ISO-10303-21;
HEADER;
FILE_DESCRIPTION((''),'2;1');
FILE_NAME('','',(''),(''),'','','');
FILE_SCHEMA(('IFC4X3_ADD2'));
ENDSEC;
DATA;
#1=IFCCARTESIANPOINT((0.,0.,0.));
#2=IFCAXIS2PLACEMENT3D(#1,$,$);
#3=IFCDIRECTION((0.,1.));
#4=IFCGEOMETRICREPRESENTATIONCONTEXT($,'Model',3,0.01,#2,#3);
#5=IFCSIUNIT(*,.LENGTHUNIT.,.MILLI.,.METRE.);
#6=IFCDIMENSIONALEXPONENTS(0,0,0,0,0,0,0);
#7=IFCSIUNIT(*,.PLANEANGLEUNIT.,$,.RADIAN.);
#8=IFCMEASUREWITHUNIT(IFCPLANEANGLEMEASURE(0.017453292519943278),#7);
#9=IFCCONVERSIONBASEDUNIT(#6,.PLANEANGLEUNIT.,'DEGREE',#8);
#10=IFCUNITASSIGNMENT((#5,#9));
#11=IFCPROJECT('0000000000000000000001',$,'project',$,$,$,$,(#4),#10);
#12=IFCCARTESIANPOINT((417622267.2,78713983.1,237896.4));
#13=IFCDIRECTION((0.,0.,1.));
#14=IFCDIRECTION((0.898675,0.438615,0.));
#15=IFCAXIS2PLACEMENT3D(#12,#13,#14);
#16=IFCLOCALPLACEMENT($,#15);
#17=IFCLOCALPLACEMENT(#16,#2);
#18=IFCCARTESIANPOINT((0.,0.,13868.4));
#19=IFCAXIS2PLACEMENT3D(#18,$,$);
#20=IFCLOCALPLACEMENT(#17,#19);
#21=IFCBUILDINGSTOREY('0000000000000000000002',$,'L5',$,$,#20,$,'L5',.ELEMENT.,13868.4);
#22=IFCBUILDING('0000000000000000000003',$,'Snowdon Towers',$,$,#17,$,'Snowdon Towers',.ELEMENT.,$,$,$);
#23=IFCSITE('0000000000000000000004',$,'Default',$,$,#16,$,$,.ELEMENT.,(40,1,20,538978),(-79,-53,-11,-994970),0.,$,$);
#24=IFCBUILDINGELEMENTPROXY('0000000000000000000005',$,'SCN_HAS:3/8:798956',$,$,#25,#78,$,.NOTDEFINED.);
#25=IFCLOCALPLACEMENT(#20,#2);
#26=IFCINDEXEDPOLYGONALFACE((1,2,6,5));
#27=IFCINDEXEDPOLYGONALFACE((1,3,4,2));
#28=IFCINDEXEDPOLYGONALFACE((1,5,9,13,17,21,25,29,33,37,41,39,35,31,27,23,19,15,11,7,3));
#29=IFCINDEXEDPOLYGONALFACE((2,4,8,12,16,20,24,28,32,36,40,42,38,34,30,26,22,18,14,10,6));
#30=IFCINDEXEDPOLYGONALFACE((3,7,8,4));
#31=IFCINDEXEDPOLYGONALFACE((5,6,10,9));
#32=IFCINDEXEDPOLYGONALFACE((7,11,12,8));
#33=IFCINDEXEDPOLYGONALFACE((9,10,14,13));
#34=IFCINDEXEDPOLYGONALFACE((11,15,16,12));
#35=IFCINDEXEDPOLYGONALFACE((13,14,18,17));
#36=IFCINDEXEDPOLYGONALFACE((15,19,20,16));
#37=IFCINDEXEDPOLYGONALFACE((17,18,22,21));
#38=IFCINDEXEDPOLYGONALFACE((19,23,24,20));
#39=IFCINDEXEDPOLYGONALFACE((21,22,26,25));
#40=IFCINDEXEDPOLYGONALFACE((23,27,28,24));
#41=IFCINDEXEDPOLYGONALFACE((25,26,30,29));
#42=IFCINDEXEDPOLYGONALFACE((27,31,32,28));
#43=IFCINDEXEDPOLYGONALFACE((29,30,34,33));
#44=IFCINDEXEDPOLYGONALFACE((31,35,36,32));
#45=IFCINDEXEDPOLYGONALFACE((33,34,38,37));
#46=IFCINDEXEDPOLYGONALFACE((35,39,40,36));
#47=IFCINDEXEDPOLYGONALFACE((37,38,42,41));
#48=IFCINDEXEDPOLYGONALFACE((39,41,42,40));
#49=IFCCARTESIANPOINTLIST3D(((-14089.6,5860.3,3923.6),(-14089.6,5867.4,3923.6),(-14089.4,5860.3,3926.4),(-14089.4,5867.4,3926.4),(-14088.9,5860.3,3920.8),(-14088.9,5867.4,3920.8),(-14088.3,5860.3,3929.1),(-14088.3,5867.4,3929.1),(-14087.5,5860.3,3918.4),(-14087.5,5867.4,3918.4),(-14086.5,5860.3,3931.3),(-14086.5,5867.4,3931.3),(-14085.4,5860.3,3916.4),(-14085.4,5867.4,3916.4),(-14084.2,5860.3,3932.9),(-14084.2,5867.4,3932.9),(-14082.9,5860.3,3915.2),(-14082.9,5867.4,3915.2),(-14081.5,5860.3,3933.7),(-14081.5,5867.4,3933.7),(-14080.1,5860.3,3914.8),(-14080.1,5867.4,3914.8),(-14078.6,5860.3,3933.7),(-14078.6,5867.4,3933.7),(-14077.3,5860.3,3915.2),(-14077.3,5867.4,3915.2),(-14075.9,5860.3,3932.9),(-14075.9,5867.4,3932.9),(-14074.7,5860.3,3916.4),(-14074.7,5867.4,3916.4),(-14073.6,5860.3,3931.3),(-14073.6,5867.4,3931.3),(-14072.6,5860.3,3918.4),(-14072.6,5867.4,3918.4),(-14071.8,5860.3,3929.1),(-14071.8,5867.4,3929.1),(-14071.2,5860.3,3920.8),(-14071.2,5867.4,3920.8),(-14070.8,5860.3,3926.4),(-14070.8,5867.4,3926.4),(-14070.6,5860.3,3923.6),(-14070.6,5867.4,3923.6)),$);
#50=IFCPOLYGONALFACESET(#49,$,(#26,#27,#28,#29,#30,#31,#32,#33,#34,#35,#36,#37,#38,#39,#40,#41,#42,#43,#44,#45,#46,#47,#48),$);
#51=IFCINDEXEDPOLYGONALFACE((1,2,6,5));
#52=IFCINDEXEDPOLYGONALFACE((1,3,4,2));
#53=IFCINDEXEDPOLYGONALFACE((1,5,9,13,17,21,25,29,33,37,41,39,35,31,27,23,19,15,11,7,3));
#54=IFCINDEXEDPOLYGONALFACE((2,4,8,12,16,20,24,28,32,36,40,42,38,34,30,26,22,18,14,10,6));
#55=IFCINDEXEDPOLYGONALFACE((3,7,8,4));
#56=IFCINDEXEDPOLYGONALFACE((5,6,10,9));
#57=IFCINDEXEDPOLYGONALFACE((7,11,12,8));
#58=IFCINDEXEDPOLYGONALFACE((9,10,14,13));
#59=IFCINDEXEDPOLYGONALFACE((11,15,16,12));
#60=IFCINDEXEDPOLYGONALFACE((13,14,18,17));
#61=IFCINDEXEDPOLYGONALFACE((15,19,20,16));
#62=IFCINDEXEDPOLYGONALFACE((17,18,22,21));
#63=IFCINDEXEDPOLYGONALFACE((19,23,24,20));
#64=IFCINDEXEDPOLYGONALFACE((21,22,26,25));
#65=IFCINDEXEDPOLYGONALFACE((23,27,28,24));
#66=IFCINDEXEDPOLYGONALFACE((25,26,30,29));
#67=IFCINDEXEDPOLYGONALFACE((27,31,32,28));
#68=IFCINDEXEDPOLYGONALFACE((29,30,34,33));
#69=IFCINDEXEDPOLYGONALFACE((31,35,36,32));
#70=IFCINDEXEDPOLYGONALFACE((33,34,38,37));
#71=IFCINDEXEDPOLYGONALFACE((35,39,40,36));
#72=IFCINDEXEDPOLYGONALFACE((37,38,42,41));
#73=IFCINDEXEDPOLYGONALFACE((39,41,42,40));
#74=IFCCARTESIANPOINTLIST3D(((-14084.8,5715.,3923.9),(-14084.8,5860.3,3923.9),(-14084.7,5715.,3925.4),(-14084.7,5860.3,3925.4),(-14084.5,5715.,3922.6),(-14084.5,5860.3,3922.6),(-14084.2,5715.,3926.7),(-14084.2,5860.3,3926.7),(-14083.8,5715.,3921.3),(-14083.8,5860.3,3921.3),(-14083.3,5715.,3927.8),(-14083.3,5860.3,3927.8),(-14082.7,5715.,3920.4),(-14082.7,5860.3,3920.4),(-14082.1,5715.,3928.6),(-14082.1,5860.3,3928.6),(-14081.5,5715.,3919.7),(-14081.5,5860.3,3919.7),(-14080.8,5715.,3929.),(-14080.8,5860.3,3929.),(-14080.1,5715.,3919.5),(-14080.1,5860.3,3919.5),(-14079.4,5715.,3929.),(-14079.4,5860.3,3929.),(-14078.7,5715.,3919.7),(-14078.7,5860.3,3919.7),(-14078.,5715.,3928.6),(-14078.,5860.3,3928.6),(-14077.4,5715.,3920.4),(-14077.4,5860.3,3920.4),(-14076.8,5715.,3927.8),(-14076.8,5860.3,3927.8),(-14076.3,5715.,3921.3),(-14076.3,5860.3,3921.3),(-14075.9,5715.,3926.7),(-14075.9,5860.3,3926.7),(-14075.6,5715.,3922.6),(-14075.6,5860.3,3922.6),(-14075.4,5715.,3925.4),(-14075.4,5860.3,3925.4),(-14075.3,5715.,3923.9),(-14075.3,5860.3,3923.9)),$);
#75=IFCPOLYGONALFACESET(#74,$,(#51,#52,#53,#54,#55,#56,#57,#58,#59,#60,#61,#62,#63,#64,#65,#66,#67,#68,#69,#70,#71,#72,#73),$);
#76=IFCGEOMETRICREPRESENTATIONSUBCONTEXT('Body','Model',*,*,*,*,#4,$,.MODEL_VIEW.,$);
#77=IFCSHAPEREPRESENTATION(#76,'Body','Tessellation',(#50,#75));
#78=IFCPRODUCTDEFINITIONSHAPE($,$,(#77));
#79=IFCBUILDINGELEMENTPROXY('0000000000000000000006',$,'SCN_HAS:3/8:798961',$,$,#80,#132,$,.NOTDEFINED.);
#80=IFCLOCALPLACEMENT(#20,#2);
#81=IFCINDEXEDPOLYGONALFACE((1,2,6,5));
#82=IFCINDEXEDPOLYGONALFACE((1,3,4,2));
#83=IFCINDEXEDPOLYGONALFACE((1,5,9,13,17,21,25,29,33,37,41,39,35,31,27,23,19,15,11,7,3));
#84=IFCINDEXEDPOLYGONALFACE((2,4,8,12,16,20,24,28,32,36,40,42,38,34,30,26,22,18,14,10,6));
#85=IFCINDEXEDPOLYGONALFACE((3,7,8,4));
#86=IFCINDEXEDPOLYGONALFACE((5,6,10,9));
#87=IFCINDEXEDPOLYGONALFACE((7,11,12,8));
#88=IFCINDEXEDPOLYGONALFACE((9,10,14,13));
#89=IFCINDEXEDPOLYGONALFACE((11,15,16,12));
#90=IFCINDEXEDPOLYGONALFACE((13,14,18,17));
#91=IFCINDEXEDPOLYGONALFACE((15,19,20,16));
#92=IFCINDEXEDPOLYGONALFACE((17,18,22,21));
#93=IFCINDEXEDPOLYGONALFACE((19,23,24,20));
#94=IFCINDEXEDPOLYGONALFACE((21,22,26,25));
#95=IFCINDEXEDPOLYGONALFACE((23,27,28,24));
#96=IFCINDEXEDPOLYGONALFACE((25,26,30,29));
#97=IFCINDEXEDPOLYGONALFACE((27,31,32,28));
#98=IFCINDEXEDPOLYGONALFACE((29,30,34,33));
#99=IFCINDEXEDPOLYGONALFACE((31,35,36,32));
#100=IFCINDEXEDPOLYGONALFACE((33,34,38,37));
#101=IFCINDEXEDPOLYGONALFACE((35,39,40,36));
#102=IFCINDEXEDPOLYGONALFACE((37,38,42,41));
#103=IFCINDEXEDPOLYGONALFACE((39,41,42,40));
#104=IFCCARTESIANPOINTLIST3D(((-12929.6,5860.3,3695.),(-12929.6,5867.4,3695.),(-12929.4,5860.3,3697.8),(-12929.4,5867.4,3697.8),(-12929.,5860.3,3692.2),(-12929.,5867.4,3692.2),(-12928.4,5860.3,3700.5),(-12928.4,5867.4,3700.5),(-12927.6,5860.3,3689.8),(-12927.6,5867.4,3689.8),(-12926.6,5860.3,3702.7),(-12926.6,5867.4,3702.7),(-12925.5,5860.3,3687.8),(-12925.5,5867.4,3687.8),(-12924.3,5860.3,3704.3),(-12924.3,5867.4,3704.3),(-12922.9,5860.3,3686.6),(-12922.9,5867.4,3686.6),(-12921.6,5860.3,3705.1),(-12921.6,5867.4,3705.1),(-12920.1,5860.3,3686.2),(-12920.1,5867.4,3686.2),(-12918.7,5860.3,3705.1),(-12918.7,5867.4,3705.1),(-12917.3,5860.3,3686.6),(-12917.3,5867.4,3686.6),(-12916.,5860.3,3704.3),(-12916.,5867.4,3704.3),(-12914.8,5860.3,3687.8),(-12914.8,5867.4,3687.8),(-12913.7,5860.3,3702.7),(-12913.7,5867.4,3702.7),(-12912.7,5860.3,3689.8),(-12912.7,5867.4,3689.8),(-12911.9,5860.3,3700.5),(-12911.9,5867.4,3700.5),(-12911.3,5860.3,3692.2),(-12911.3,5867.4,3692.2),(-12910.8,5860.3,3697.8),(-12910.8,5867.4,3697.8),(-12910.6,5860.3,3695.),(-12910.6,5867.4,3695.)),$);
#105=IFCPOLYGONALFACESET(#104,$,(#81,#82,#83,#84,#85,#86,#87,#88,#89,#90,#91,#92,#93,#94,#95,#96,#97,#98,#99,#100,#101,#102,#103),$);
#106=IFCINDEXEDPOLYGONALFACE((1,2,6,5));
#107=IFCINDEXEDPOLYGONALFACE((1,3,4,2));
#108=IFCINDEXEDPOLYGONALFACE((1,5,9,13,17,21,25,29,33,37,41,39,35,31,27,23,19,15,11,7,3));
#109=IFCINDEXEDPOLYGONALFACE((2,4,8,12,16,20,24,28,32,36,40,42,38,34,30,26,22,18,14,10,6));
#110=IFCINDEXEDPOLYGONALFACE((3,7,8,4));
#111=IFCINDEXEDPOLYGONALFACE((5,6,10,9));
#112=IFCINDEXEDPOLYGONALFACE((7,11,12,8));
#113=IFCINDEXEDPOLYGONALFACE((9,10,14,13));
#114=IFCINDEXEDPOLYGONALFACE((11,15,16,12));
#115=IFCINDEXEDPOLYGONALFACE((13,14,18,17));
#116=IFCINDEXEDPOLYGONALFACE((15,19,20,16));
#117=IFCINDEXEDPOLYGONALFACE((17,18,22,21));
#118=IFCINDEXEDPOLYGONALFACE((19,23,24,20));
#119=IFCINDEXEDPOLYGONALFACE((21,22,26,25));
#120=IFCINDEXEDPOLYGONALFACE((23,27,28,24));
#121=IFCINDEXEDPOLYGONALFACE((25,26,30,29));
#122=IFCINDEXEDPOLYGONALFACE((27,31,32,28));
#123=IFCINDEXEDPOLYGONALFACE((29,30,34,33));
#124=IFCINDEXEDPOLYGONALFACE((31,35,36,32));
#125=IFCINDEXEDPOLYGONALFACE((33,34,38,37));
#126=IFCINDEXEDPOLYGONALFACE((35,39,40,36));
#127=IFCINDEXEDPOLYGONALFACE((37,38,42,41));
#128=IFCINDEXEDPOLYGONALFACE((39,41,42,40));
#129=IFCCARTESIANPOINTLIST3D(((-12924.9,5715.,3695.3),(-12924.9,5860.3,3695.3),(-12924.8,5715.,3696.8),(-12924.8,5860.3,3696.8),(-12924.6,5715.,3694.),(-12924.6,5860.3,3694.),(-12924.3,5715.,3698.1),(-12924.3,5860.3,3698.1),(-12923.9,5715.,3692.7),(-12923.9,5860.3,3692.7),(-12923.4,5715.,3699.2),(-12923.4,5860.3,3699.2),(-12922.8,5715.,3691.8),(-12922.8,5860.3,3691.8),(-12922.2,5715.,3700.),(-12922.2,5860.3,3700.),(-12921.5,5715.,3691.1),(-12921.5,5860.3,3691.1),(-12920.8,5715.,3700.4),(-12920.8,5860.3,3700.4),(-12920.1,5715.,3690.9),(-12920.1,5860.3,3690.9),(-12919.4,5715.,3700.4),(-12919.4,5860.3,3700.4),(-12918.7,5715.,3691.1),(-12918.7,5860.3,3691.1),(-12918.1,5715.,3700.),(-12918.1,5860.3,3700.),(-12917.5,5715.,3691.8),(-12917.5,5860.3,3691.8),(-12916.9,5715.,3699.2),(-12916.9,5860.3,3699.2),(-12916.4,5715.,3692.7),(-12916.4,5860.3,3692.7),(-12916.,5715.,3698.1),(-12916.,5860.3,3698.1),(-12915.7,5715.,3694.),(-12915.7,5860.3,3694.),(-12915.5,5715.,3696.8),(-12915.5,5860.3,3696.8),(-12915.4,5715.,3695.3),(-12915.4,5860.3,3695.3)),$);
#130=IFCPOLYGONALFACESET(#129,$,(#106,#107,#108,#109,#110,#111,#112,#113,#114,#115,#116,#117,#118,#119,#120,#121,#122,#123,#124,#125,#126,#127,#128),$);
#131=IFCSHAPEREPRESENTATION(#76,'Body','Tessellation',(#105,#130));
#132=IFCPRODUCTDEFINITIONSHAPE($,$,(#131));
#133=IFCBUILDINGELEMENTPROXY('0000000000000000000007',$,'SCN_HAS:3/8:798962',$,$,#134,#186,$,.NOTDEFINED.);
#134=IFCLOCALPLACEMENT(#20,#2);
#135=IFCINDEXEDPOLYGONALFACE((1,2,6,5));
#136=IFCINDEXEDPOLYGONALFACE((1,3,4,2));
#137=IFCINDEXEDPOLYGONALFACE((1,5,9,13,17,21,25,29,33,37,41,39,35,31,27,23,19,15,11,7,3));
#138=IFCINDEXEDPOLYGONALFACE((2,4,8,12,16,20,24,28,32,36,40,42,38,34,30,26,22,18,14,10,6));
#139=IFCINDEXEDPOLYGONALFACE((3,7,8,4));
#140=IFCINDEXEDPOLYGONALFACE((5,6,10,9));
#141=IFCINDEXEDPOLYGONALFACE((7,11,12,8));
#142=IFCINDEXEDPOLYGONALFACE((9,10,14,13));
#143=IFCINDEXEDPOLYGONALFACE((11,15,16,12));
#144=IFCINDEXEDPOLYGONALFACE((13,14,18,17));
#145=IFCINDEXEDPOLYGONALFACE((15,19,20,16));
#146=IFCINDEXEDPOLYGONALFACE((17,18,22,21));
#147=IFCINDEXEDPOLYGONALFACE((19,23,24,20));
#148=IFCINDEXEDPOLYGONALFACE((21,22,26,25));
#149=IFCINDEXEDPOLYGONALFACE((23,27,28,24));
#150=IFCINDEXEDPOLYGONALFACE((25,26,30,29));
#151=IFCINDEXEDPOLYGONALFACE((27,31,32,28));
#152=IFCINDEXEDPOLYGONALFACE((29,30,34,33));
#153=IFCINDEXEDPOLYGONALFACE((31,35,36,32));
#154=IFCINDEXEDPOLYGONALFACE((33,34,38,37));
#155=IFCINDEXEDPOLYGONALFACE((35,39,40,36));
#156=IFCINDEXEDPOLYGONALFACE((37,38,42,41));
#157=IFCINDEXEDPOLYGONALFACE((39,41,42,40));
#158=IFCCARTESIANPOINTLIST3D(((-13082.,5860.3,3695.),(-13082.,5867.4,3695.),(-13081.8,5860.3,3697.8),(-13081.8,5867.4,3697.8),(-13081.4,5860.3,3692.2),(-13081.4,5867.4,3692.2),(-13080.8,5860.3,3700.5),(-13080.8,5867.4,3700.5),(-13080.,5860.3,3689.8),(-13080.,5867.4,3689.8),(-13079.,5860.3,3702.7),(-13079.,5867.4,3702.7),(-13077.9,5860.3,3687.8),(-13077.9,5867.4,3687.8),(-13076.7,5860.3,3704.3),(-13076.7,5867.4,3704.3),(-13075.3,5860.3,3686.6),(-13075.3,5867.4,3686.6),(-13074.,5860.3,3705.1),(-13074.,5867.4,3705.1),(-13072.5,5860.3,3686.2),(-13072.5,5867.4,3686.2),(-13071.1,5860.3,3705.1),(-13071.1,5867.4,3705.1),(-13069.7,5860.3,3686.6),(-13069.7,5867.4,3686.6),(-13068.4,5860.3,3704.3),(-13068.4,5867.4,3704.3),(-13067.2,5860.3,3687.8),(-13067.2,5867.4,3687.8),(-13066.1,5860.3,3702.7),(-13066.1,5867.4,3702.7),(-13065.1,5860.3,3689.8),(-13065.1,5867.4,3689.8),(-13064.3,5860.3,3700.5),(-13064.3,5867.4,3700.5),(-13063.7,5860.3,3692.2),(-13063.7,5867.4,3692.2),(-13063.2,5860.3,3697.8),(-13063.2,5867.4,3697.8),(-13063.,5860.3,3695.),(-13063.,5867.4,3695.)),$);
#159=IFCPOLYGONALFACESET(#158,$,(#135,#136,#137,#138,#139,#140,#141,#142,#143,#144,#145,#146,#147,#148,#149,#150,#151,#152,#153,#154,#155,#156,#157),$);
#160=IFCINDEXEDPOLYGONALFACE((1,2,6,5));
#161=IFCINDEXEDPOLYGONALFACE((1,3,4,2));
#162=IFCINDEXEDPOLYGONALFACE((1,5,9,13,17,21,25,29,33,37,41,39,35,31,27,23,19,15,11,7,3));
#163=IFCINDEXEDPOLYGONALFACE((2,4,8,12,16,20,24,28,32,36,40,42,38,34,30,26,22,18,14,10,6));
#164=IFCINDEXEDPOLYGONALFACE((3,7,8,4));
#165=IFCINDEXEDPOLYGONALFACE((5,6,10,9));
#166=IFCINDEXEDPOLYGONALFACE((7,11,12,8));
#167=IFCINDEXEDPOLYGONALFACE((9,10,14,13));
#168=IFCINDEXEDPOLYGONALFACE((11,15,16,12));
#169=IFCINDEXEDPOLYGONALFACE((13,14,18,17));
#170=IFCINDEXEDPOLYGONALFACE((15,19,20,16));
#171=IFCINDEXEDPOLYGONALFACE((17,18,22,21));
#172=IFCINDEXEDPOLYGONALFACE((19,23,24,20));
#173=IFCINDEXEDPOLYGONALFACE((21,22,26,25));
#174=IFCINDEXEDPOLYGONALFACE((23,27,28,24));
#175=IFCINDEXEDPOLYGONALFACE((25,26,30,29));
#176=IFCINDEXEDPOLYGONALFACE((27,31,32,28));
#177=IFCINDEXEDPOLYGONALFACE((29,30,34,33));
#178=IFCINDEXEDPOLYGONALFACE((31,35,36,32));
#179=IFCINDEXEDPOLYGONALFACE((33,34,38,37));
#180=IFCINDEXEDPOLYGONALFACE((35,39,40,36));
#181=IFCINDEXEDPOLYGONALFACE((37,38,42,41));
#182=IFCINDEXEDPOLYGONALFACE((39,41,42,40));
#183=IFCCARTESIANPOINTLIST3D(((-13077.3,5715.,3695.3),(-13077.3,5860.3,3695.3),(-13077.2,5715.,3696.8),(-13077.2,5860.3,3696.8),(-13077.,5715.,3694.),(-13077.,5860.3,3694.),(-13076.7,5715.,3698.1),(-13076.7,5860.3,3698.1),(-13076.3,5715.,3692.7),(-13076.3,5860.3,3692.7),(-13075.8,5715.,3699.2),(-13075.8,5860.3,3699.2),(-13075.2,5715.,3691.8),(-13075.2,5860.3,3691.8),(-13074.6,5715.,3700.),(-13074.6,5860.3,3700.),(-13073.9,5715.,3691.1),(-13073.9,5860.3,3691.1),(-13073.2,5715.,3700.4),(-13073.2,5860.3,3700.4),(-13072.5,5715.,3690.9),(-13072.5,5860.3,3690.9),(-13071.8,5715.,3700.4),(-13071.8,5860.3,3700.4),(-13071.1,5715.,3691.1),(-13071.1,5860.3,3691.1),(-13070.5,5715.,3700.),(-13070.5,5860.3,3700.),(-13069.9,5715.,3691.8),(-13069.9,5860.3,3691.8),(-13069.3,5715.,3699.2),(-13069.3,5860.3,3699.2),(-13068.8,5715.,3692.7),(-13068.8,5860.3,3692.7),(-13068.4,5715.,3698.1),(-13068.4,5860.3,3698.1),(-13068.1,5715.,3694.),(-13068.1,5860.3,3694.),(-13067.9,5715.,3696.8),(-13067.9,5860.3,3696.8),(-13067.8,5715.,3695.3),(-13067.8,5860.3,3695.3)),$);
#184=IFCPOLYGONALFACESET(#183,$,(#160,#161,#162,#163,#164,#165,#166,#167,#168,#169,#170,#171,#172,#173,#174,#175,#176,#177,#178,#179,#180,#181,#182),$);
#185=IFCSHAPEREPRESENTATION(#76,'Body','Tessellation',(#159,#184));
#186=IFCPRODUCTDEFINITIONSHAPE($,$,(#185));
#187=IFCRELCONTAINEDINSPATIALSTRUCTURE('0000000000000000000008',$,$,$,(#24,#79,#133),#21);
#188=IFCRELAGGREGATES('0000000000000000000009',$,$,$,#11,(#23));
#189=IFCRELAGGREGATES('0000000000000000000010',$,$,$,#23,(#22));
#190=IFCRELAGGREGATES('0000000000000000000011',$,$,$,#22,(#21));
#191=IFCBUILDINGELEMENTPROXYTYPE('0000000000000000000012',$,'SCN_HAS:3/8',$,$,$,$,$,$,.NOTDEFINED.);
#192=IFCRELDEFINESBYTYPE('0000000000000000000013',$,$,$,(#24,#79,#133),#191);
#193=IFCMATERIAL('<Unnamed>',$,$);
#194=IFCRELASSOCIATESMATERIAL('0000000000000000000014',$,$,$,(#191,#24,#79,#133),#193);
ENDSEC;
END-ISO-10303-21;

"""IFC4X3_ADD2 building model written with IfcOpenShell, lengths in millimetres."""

from ifc_helpers import new_model, entity, si_unit, converted_unit, direction, frame, frame_2d, origin, place, context, subcontext, project, spatial, circle, extrude, source, transform, mapped, material, type_object, type_shapes, element, save


model = new_model("IFC4X3_ADD2")

# Units and contexts
model_context = context("Model", 3, precision=0.01, world=origin(), true_north=direction((0.0, 1.0)))
body_context = subcontext(model_context, "Body", "Model", "MODEL_VIEW")
ifc_project = project(units=[si_unit("LENGTHUNIT", "METRE", prefix="MILLI"), converted_unit("PLANEANGLEUNIT", "DEGREE", entity("IfcPlaneAngleMeasure", 0.017453292519943278), si_unit("PLANEANGLEUNIT", "RADIAN"), dimensions=[0, 0, 0, 0, 0, 0, 0])], contexts=[model_context])

# Site, building, storey
site_placement = place(None, frame((417622267.2, 78713983.1, 237896.4), z_axis=(0.0, 0.0, 1.0), x_axis=(0.898675, 0.438615, 0.0)))
site = spatial("IfcSite", under=ifc_project, at=site_placement, Name="Default", CompositionType="ELEMENT", RefLatitude=(40, 1, 20, 538978), RefLongitude=(-79, -53, -11, -994970), RefElevation=0.0)
building_placement = place(site_placement, origin())
building = spatial("IfcBuilding", under=site, at=building_placement, Name="Snowdon Towers", LongName="Snowdon Towers", CompositionType="ELEMENT")
storey_placement = place(building_placement, frame((0.0, 0.0, 13868.4)))
storey = spatial("IfcBuildingStorey", under=building, at=storey_placement, Name="L5", LongName="L5", CompositionType="ELEMENT", Elevation=13868.4)

# Building element proxies
ifc_material_1 = material(Name="<Unnamed>")
building_element_proxy_type = type_object("IfcBuildingElementProxyType", Name="SCN_HAS:3/8", PredefinedType="NOTDEFINED", material=ifc_material_1)
shared_shape_1 = source(origin(), body_context, "Body", "SweptSolid", [
    extrude(circle(Radius=9.5, at=frame_2d((0.0, 0.0), x_axis=(1.0, 0.0))), frame((0.0, 0.0, -152.4), z_axis=(0.0, 0.0, 1.0), x_axis=(0.0, -1.0, 0.0)), (0.0, 0.0, 1.0), 7.1),
    extrude(circle(Radius=4.8, at=frame_2d((0.0, 0.0), x_axis=(1.0, 0.0))), frame((0.0, 0.0, -145.3), z_axis=(0.0, 0.0, 1.0), x_axis=(0.0, -1.0, 0.0)), (0.0, 0.0, 1.0), 145.3),
])
type_shapes(building_element_proxy_type, [shared_shape_1])
for number, where, z_axis, x_axis, name in (
    (1, (-14080.1, 5715.0, 3924.3), (0.0, -1.0, 0.0), (1.0, 0.0, 0.0), "SCN_HAS:3/8:798956"),
    (2, (-12920.1, 5715.0, 3695.7), (0.0, -1.0, 0.0), (1.0, 0.0, 0.0), "SCN_HAS:3/8:798961"),
    (3, (-13072.5, 5715.0, 3695.7), (0.0, -1.0, 0.0), (1.0, 0.0, 0.0), "SCN_HAS:3/8:798962"),
):
    element("IfcBuildingElementProxy", number, at=place(storey_placement, frame(where, z_axis=z_axis, x_axis=x_axis)), inside=storey, type_object=building_element_proxy_type, material=ifc_material_1, Name=name, PredefinedType="NOTDEFINED", context=body_context, shape_type="MappedRepresentation", body=[
        mapped(shared_shape_1, transform((0.0, 0.0, 0.0), scale=1.0)),
    ])

save(model, "model.ifc")
